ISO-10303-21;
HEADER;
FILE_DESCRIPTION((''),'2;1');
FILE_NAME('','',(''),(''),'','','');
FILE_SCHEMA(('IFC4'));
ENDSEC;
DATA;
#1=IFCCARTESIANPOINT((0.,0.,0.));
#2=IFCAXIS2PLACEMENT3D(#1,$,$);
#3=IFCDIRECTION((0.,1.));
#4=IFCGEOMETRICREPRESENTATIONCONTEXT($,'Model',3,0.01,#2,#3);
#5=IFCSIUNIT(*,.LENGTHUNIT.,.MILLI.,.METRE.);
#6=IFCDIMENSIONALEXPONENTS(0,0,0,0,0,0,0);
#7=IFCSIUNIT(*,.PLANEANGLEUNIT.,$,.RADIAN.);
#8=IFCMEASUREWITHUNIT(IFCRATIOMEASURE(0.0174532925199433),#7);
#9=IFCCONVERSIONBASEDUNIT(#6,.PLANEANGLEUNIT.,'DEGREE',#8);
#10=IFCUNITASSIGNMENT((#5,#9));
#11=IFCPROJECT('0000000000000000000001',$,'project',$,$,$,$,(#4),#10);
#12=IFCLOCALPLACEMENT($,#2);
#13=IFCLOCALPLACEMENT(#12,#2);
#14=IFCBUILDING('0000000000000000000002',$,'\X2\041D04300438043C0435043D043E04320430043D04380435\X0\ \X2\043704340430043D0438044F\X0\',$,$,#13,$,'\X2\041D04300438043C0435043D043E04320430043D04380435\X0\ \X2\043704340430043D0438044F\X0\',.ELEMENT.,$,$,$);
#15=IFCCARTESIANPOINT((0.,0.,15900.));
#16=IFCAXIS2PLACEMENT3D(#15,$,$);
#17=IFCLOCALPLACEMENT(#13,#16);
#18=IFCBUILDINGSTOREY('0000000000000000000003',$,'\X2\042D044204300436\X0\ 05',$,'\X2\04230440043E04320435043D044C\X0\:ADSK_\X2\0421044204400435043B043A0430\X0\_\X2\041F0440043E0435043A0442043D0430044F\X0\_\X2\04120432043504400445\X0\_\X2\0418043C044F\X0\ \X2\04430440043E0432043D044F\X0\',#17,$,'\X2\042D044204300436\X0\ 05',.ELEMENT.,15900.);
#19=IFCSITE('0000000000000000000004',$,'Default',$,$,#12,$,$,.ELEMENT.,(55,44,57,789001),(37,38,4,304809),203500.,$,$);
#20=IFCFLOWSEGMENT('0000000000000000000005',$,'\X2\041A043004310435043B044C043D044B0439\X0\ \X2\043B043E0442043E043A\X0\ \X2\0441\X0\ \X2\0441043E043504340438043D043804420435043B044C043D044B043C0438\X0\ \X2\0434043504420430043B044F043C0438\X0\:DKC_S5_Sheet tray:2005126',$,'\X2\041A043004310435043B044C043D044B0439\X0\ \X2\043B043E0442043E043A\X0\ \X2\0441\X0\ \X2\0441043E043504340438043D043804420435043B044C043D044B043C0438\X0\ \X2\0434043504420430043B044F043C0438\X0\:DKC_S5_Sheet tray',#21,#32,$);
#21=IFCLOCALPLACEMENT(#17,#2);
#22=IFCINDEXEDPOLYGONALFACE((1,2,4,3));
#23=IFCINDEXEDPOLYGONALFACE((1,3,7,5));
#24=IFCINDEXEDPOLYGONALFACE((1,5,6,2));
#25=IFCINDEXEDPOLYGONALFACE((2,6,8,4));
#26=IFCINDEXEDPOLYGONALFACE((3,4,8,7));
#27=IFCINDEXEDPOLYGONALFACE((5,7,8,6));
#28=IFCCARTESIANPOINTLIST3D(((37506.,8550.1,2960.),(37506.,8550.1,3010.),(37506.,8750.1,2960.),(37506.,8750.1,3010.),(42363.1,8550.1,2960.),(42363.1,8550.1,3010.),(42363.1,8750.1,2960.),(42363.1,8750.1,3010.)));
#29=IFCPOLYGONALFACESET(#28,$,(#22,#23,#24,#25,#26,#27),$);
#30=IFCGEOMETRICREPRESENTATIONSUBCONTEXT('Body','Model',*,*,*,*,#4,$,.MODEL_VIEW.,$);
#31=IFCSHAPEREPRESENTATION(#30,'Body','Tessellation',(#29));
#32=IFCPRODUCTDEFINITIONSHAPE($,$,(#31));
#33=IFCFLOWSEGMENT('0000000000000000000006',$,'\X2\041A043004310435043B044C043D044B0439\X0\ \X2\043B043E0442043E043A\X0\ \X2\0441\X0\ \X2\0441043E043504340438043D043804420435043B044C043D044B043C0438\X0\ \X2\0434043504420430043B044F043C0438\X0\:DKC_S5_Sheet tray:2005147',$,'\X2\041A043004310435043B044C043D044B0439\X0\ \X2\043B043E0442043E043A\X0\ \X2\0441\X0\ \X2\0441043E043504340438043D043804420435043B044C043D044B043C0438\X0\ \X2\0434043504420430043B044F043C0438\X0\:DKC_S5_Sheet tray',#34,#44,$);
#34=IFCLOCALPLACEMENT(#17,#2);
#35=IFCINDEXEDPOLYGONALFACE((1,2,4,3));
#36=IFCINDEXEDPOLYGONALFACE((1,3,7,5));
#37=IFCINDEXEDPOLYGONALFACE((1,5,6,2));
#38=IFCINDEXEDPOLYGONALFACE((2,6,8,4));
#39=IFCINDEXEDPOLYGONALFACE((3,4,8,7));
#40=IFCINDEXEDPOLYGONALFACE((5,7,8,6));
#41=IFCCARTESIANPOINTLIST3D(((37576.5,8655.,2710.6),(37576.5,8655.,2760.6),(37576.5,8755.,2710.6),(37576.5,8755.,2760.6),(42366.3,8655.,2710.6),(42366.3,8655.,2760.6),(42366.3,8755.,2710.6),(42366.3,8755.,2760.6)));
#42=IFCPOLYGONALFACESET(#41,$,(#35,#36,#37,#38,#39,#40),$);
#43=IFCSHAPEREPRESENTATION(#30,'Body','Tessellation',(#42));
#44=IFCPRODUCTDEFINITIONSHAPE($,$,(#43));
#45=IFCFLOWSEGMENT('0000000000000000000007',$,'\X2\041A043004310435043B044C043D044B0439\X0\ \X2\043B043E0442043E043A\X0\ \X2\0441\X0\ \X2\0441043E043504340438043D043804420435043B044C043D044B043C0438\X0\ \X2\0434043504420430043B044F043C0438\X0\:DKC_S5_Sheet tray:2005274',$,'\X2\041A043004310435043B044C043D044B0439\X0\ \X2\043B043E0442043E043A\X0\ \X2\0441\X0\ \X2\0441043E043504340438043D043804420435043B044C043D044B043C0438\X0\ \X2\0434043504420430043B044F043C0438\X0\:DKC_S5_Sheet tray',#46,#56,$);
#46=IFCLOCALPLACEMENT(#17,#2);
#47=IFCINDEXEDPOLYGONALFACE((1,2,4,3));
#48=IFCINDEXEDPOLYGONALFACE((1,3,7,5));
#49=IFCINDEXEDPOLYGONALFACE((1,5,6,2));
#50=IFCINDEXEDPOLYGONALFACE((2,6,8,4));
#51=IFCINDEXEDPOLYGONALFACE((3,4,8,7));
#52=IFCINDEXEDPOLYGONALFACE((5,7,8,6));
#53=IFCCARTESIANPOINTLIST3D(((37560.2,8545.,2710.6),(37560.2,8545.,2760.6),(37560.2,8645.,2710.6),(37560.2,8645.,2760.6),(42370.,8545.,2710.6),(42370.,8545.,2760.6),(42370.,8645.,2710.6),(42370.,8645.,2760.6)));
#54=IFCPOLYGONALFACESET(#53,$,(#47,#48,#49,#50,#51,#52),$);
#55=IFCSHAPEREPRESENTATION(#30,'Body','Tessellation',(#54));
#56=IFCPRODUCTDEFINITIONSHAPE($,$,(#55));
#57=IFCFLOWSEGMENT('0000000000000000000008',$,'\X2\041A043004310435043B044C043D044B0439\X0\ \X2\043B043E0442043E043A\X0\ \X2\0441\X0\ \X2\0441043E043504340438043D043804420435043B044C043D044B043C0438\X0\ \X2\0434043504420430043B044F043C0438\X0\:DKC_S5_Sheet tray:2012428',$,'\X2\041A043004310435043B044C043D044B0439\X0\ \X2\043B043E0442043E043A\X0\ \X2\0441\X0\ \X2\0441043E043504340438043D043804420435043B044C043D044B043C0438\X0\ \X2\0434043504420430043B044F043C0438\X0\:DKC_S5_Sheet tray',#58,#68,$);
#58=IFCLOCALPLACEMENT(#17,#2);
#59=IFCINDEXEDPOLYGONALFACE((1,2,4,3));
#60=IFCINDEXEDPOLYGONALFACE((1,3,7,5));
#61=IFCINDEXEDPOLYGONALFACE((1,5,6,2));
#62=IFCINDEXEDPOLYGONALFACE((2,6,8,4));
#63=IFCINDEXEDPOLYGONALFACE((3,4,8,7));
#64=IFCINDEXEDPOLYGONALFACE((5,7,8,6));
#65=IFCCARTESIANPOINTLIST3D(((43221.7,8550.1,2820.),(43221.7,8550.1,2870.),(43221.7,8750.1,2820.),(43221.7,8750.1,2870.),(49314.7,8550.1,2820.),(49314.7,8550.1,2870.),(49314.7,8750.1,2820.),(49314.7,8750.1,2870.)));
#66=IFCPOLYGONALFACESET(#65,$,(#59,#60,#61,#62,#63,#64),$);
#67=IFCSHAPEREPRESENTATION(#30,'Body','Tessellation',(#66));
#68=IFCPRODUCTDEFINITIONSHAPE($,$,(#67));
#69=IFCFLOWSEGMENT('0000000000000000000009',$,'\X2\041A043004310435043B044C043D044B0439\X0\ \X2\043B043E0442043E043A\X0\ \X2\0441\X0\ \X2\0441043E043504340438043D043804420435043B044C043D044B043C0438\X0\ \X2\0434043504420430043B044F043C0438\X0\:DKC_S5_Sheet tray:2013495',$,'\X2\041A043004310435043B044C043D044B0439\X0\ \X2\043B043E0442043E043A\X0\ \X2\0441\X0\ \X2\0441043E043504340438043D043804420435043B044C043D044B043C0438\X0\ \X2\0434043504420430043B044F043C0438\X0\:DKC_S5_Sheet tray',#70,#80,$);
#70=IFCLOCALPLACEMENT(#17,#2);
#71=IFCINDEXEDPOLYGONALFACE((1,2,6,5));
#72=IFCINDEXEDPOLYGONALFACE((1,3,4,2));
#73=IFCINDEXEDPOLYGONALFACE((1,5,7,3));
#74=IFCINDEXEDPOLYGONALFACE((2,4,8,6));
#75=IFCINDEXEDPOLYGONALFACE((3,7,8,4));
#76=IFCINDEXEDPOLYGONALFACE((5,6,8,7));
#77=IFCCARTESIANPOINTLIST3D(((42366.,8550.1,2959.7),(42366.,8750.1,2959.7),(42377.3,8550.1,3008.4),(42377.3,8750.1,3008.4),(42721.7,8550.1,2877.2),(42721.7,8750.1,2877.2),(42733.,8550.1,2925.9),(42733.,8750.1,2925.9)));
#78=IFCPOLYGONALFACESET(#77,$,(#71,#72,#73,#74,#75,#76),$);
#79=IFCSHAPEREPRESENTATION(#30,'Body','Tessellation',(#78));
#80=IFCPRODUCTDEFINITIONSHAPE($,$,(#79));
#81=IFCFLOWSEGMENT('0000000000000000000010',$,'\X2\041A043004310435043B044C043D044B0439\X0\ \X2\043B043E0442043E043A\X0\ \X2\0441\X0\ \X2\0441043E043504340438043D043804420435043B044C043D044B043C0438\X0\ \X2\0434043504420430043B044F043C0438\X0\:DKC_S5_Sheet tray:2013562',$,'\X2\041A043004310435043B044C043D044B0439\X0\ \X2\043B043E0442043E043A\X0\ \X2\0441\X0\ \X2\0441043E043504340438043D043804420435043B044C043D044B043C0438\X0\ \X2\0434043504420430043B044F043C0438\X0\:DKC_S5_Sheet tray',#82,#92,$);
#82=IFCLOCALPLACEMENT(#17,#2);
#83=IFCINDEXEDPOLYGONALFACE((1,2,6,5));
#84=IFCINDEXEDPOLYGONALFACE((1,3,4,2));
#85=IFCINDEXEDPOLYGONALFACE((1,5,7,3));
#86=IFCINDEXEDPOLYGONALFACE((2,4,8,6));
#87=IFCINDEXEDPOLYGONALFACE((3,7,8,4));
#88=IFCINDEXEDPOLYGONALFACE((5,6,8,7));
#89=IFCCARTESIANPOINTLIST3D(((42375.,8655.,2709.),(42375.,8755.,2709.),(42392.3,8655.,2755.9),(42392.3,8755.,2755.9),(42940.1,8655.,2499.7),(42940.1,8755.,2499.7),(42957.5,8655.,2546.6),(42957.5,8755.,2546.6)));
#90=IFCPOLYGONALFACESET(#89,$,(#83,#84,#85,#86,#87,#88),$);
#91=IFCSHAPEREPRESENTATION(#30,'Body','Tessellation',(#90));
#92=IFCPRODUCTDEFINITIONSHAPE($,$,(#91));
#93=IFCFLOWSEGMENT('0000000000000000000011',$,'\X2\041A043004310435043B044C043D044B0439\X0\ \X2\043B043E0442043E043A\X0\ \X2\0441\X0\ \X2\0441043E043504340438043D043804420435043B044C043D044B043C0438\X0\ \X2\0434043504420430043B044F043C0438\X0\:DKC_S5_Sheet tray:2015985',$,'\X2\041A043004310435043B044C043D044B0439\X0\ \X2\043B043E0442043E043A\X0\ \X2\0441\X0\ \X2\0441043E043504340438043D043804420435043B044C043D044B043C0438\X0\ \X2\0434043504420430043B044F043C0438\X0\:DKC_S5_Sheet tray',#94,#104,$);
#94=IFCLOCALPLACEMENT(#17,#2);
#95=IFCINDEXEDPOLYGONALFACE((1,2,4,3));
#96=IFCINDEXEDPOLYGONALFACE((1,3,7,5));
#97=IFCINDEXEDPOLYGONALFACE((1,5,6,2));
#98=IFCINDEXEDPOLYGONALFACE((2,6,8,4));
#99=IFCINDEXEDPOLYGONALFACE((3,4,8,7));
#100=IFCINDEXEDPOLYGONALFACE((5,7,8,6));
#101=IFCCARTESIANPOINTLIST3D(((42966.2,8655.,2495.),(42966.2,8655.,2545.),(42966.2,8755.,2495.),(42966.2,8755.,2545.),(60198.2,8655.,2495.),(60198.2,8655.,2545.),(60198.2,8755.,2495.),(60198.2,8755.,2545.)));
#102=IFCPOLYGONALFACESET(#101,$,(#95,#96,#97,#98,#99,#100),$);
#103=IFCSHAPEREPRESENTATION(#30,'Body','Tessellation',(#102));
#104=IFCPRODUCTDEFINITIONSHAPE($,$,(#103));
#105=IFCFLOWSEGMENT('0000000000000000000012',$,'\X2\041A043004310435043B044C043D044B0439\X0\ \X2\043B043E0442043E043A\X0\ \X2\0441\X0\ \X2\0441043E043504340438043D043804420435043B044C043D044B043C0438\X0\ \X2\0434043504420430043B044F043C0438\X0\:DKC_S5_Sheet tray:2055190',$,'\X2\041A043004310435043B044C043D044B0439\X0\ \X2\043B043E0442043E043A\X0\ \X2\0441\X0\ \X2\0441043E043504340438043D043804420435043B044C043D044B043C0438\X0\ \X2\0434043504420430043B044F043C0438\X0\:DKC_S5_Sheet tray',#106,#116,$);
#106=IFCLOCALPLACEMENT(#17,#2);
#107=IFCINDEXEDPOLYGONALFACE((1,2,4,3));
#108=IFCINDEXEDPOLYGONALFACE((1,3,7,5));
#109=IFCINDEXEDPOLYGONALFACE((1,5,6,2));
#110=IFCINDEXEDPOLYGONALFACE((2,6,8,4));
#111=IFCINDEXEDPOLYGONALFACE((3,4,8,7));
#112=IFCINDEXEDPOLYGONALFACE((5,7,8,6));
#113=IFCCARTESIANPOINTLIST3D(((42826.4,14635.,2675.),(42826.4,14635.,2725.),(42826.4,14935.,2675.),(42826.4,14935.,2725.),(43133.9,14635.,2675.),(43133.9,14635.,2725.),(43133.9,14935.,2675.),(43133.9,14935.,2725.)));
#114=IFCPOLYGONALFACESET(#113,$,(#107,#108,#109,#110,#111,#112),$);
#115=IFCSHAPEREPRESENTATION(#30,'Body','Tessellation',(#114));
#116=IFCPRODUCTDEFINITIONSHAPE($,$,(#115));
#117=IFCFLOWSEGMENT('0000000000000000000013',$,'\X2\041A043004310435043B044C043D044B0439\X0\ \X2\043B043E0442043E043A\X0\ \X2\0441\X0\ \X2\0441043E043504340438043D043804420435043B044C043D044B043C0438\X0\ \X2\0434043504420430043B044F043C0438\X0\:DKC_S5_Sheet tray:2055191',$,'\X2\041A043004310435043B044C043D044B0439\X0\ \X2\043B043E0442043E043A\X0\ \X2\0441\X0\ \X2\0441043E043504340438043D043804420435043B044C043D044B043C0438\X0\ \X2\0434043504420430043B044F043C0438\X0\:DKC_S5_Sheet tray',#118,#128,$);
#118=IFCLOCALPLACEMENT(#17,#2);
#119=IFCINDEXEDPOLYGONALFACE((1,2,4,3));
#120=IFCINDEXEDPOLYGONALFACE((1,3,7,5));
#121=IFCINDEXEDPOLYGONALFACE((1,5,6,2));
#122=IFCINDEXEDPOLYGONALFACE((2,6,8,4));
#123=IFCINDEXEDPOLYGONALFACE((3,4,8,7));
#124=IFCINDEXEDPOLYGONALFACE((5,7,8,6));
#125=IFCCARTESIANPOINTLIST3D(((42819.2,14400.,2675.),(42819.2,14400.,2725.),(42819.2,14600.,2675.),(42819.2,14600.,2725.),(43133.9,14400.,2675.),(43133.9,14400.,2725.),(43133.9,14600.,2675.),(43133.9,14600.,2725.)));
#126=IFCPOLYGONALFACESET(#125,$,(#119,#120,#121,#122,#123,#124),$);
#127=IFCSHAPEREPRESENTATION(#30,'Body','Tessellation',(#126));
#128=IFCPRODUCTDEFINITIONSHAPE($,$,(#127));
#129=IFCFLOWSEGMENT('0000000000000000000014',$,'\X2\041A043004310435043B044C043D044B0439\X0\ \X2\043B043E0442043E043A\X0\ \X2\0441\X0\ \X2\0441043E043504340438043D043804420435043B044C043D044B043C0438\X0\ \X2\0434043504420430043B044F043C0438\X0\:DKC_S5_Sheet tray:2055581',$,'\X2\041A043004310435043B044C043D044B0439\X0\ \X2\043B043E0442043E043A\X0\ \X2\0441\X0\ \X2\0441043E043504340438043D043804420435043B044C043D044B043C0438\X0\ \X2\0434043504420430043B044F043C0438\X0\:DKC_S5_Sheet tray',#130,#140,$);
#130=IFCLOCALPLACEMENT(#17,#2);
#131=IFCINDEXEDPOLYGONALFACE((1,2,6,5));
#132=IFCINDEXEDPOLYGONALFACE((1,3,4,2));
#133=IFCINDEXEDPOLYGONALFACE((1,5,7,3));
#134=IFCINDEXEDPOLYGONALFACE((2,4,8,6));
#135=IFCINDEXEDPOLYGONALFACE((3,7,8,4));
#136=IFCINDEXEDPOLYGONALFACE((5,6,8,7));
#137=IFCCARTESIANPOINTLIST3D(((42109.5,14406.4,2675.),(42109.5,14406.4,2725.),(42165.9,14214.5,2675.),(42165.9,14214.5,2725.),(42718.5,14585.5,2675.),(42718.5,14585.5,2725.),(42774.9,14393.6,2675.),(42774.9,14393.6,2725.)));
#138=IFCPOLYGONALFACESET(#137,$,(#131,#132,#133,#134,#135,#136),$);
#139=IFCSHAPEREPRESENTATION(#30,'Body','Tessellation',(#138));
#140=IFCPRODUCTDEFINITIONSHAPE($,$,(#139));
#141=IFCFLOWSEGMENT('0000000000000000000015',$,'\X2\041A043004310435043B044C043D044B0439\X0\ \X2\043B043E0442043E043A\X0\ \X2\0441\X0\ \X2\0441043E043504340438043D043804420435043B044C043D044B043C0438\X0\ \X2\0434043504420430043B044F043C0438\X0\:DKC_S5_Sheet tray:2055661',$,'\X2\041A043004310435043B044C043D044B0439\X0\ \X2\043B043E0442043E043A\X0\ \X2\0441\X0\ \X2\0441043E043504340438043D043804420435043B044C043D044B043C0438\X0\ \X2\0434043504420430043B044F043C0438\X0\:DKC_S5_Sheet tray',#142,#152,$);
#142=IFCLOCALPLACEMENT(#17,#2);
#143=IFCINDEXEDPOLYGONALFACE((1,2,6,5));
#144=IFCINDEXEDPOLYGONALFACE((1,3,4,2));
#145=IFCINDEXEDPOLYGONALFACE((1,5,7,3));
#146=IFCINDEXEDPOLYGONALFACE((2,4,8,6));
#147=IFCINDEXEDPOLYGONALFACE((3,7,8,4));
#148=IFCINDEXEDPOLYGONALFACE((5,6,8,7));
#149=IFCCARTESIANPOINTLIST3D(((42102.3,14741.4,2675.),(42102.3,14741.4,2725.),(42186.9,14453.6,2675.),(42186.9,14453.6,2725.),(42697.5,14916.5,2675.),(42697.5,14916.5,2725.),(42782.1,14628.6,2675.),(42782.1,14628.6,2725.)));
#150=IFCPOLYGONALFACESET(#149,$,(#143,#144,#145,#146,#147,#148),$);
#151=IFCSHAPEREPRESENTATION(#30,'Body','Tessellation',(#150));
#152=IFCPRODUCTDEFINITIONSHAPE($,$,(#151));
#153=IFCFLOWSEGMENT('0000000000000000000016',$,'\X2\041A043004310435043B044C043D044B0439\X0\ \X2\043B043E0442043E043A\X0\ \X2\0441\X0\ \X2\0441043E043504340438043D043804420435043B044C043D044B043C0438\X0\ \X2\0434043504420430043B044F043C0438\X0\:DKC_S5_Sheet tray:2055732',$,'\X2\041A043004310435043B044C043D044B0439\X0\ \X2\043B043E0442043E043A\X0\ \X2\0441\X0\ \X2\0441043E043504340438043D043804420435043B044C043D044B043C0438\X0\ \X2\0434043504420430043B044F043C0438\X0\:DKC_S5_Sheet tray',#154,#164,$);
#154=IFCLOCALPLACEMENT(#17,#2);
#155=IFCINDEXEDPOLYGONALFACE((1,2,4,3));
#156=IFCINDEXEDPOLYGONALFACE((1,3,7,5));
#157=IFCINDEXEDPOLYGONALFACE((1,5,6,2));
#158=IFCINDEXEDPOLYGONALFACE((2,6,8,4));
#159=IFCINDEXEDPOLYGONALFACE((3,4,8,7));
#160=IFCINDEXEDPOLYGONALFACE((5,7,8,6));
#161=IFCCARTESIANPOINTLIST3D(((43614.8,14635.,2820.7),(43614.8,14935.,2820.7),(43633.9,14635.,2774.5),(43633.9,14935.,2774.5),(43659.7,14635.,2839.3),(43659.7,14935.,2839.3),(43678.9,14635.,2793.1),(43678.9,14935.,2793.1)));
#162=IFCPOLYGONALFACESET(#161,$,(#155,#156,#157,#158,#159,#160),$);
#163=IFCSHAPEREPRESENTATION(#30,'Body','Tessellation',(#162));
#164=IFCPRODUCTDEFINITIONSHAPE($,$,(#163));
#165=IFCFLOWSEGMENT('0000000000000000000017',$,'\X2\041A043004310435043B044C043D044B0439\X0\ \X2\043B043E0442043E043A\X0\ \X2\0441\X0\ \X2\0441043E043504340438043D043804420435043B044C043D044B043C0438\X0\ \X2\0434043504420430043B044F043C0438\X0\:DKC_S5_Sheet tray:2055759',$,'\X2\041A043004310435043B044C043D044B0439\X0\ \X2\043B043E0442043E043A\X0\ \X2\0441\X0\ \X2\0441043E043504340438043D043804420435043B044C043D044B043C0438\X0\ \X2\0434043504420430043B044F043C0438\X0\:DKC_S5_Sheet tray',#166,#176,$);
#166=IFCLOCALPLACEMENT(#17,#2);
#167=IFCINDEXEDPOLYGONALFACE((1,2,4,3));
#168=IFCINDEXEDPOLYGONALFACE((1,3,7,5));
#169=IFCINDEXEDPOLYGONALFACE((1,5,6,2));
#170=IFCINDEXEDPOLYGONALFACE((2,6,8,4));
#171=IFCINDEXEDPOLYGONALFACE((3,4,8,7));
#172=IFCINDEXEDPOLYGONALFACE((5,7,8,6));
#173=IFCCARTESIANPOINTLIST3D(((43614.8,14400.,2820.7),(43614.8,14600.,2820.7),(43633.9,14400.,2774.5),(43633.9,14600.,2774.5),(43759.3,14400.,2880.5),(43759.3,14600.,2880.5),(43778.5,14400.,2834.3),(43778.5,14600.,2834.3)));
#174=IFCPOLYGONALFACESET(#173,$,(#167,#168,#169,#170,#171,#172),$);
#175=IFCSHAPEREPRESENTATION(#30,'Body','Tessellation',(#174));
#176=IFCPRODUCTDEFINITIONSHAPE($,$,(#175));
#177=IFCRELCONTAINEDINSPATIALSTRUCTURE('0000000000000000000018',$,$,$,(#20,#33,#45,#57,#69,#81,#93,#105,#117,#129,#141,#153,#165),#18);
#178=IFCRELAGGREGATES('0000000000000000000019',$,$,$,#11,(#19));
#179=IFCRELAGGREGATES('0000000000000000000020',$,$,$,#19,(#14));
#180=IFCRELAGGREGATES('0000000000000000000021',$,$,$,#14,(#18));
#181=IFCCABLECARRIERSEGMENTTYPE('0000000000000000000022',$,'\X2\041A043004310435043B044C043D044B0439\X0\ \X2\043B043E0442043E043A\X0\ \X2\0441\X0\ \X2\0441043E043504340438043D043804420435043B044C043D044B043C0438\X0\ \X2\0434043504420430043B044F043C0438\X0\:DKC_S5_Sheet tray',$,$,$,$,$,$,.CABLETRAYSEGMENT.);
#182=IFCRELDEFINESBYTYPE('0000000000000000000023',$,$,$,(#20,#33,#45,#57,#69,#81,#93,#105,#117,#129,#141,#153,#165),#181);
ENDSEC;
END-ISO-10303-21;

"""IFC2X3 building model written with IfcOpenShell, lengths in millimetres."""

from ifc_helpers import new_model, entity, si_unit, converted_unit, direction, frame, frame_2d, origin, origin_2d_with_axis, place, context, subcontext, project, spatial, rectangle, extrude, type_object, element, save


model = new_model("IFC2X3")

# Units and contexts
model_context = context("Model", 3, precision=0.01, world=origin(), true_north=direction((0.0, 1.0)))
body_context = subcontext(model_context, "Body", "Model", "MODEL_VIEW")
ifc_project = project(units=[si_unit("LENGTHUNIT", "METRE", prefix="MILLI"), converted_unit("PLANEANGLEUNIT", "DEGREE", entity("IfcRatioMeasure", 0.0174532925199433), si_unit("PLANEANGLEUNIT", "RADIAN"), dimensions=[0, 0, 0, 0, 0, 0, 0])], contexts=[model_context])

# Site, building, storey
site_placement = place(None, frame((0.0, 0.0, 0.0)))
site = spatial("IfcSite", under=ifc_project, at=site_placement, Name="Default", CompositionType="ELEMENT", RefLatitude=(55, 44, 57, 789001), RefLongitude=(37, 38, 4, 304809), RefElevation=203500.0)
building_placement = place(site_placement, origin())
building = spatial("IfcBuilding", under=site, at=building_placement, Name="Наименование здания", LongName="Наименование здания", CompositionType="ELEMENT")
storey_placement = place(building_placement, frame((0.0, 0.0, 15900.0)))
storey = spatial("IfcBuildingStorey", under=building, at=storey_placement, Name="Этаж 05", ObjectType="Уровень:ADSK_Стрелка_Проектная_Вверх_Имя уровня", LongName="Этаж 05", CompositionType="ELEMENT", Elevation=15900.0)

# Flow segments
cable_carrier_segment_type = type_object("IfcCableCarrierSegmentType", Name="Кабельный лоток с соединительными деталями:DKC_S5_Sheet tray", PredefinedType="CABLETRAYSEGMENT")
flow_segment_1_placement = place(storey_placement, frame((37506.0, 8550.1, 2960.0)))
element("IfcFlowSegment", 1, at=flow_segment_1_placement, inside=storey, type_object=cable_carrier_segment_type, Name="Кабельный лоток с соединительными деталями:DKC_S5_Sheet tray:2005126", ObjectType="Кабельный лоток с соединительными деталями:DKC_S5_Sheet tray", context=body_context, shape_type="SweptSolid", body=[
    extrude(rectangle(XDim=4857.1, YDim=200.0, at=frame_2d((0.0, 0.0), x_axis=(1.0, 0.0))), frame((2428.6, 100.0, 0.0), z_axis=(0.0, 0.0, 1.0), x_axis=(-1.0, 0.0, 0.0)), (0.0, 0.0, 1.0), 50.0),
])
flow_segment_2_placement = place(storey_placement, frame((37576.5, 8655.0, 2710.6)))
element("IfcFlowSegment", 2, at=flow_segment_2_placement, inside=storey, type_object=cable_carrier_segment_type, Name="Кабельный лоток с соединительными деталями:DKC_S5_Sheet tray:2005147", ObjectType="Кабельный лоток с соединительными деталями:DKC_S5_Sheet tray", context=body_context, shape_type="SweptSolid", body=[
    extrude(rectangle(XDim=4789.8, YDim=100.0, at=frame_2d((0.0, 0.0), x_axis=(1.0, 0.0))), frame((2394.9, 50.0, 0.0), z_axis=(0.0, 0.0, 1.0), x_axis=(-1.0, 0.0, 0.0)), (0.0, 0.0, 1.0), 50.0),
])
flow_segment_3_placement = place(storey_placement, frame((37560.2, 8545.0, 2710.6)))
element("IfcFlowSegment", 3, at=flow_segment_3_placement, inside=storey, type_object=cable_carrier_segment_type, Name="Кабельный лоток с соединительными деталями:DKC_S5_Sheet tray:2005274", ObjectType="Кабельный лоток с соединительными деталями:DKC_S5_Sheet tray", context=body_context, shape_type="SweptSolid", body=[
    extrude(rectangle(XDim=4809.8, YDim=100.0, at=frame_2d((0.0, 0.0), x_axis=(1.0, 0.0))), frame((2404.9, 50.0, 0.0), z_axis=(0.0, 0.0, 1.0), x_axis=(-1.0, 0.0, 0.0)), (0.0, 0.0, 1.0), 50.0),
])
flow_segment_4_placement = place(storey_placement, frame((43221.7, 8550.1, 2820.0)))
element("IfcFlowSegment", 4, at=flow_segment_4_placement, inside=storey, type_object=cable_carrier_segment_type, Name="Кабельный лоток с соединительными деталями:DKC_S5_Sheet tray:2012428", ObjectType="Кабельный лоток с соединительными деталями:DKC_S5_Sheet tray", context=body_context, shape_type="SweptSolid", body=[
    extrude(rectangle(XDim=6093.0, YDim=200.0, at=origin_2d_with_axis()), frame((3046.5, 100.0, 0.0), z_axis=(0.0, 0.0, 1.0), x_axis=(-1.0, 0.0, 0.0)), (0.0, 0.0, 1.0), 50.0),
])
flow_segment_5_placement = place(storey_placement, frame((42366.0, 8550.1, 2877.2)))
element("IfcFlowSegment", 5, at=flow_segment_5_placement, inside=storey, type_object=cable_carrier_segment_type, Name="Кабельный лоток с соединительными деталями:DKC_S5_Sheet tray:2013495", ObjectType="Кабельный лоток с соединительными деталями:DKC_S5_Sheet tray", context=body_context, shape_type="SweptSolid", body=[
    extrude(rectangle(XDim=50.0, YDim=200.0, at=frame_2d((0.0, 0.0), x_axis=(1.0, 0.0))), frame((5.6, 100.0, 106.8), z_axis=(0.974158, 0.0, -0.225869), x_axis=(0.225869, 0.0, 0.974158)), (0.0, 0.0, 1.0), 365.1),
])
flow_segment_6_placement = place(storey_placement, frame((42375.0, 8655.0, 2499.7)))
element("IfcFlowSegment", 6, at=flow_segment_6_placement, inside=storey, type_object=cable_carrier_segment_type, Name="Кабельный лоток с соединительными деталями:DKC_S5_Sheet tray:2013562", ObjectType="Кабельный лоток с соединительными деталями:DKC_S5_Sheet tray", context=body_context, shape_type="SweptSolid", body=[
    extrude(rectangle(XDim=50.0, YDim=100.0, at=frame_2d((0.0, 0.0), x_axis=(1.0, 0.0))), frame((8.7, 50.0, 232.8), z_axis=(0.93773, 0.0, -0.347364), x_axis=(0.347364, 0.0, 0.93773)), (0.0, 0.0, 1.0), 602.7),
])
flow_segment_7_placement = place(storey_placement, frame((42966.2, 8655.0, 2495.0)))
element("IfcFlowSegment", 7, at=flow_segment_7_placement, inside=storey, type_object=cable_carrier_segment_type, Name="Кабельный лоток с соединительными деталями:DKC_S5_Sheet tray:2015985", ObjectType="Кабельный лоток с соединительными деталями:DKC_S5_Sheet tray", context=body_context, shape_type="SweptSolid", body=[
    extrude(rectangle(XDim=17232.1, YDim=100.0, at=frame_2d((0.0, 0.0), x_axis=(1.0, 0.0))), frame((8616.0, 50.0, 0.0)), (0.0, 0.0, 1.0), 50.0),
])
flow_segment_8_placement = place(storey_placement, frame((42826.4, 14635.0, 2675.0)))
element("IfcFlowSegment", 8, at=flow_segment_8_placement, inside=storey, type_object=cable_carrier_segment_type, Name="Кабельный лоток с соединительными деталями:DKC_S5_Sheet tray:2055190", ObjectType="Кабельный лоток с соединительными деталями:DKC_S5_Sheet tray", context=body_context, shape_type="SweptSolid", body=[
    extrude(rectangle(XDim=307.6, YDim=300.0, at=frame_2d((0.0, 0.0), x_axis=(1.0, 0.0))), frame((153.8, 150.0, 0.0)), (0.0, 0.0, 1.0), 50.0),
])
flow_segment_9_placement = place(storey_placement, frame((42819.2, 14400.0, 2675.0)))
element("IfcFlowSegment", 9, at=flow_segment_9_placement, inside=storey, type_object=cable_carrier_segment_type, Name="Кабельный лоток с соединительными деталями:DKC_S5_Sheet tray:2055191", ObjectType="Кабельный лоток с соединительными деталями:DKC_S5_Sheet tray", context=body_context, shape_type="SweptSolid", body=[
    extrude(rectangle(XDim=314.8, YDim=200.0, at=frame_2d((0.0, 0.0), x_axis=(1.0, 0.0))), frame((157.4, 100.0, 0.0), z_axis=(0.0, 0.0, 1.0), x_axis=(-1.0, 0.0, 0.0)), (0.0, 0.0, 1.0), 50.0),
])
flow_segment_10_placement = place(storey_placement, frame((42109.5, 14214.5, 2675.0)))
element("IfcFlowSegment", 10, at=flow_segment_10_placement, inside=storey, type_object=cable_carrier_segment_type, Name="Кабельный лоток с соединительными деталями:DKC_S5_Sheet tray:2055581", ObjectType="Кабельный лоток с соединительными деталями:DKC_S5_Sheet tray", context=body_context, shape_type="SweptSolid", body=[
    extrude(rectangle(XDim=634.8, YDim=200.0, at=frame_2d((0.0, 0.0), x_axis=(1.0, 0.0))), frame((332.7, 185.5, 0.0), z_axis=(0.0, 0.0, 1.0), x_axis=(-0.959366, -0.282166, 0.0)), (0.0, 0.0, 1.0), 50.0),
])
flow_segment_11_placement = place(storey_placement, frame((42102.3, 14453.6, 2675.0)))
element("IfcFlowSegment", 11, at=flow_segment_11_placement, inside=storey, type_object=cable_carrier_segment_type, Name="Кабельный лоток с соединительными деталями:DKC_S5_Sheet tray:2055661", ObjectType="Кабельный лоток с соединительными деталями:DKC_S5_Sheet tray", context=body_context, shape_type="SweptSolid", body=[
    extrude(rectangle(XDim=620.4, YDim=300.0, at=origin_2d_with_axis()), frame((339.9, 231.4, 0.0), z_axis=(0.0, 0.0, 1.0), x_axis=(0.959366, 0.282166, 0.0)), (0.0, 0.0, 1.0), 50.0),
])
flow_segment_12_placement = place(storey_placement, frame((43614.8, 14635.0, 2774.5)))
element("IfcFlowSegment", 12, at=flow_segment_12_placement, inside=storey, type_object=cable_carrier_segment_type, Name="Кабельный лоток с соединительными деталями:DKC_S5_Sheet tray:2055732", ObjectType="Кабельный лоток с соединительными деталями:DKC_S5_Sheet tray", context=body_context, shape_type="SweptSolid", body=[
    extrude(rectangle(XDim=50.0, YDim=48.6, at=frame_2d((0.0, 0.0), x_axis=(0.0, 1.0))), frame((32.0, 0.0, 32.4), z_axis=(0.0, 1.0, 0.0), x_axis=(0.92388, 0.0, 0.382683)), (0.0, 0.0, 1.0), 300.0),
])
flow_segment_13_placement = place(storey_placement, frame((43614.8, 14400.0, 2774.5)))
element("IfcFlowSegment", 13, at=flow_segment_13_placement, inside=storey, type_object=cable_carrier_segment_type, Name="Кабельный лоток с соединительными деталями:DKC_S5_Sheet tray:2055759", ObjectType="Кабельный лоток с соединительными деталями:DKC_S5_Sheet tray", context=body_context, shape_type="SweptSolid", body=[
    extrude(rectangle(XDim=50.0, YDim=156.4, at=frame_2d((0.0, 0.0), x_axis=(0.0, 1.0))), frame((81.8, 0.0, 53.0), z_axis=(0.0, 1.0, 0.0), x_axis=(0.92388, 0.0, 0.382683)), (0.0, 0.0, 1.0), 200.0),
])

save(model, "model.ifc")
